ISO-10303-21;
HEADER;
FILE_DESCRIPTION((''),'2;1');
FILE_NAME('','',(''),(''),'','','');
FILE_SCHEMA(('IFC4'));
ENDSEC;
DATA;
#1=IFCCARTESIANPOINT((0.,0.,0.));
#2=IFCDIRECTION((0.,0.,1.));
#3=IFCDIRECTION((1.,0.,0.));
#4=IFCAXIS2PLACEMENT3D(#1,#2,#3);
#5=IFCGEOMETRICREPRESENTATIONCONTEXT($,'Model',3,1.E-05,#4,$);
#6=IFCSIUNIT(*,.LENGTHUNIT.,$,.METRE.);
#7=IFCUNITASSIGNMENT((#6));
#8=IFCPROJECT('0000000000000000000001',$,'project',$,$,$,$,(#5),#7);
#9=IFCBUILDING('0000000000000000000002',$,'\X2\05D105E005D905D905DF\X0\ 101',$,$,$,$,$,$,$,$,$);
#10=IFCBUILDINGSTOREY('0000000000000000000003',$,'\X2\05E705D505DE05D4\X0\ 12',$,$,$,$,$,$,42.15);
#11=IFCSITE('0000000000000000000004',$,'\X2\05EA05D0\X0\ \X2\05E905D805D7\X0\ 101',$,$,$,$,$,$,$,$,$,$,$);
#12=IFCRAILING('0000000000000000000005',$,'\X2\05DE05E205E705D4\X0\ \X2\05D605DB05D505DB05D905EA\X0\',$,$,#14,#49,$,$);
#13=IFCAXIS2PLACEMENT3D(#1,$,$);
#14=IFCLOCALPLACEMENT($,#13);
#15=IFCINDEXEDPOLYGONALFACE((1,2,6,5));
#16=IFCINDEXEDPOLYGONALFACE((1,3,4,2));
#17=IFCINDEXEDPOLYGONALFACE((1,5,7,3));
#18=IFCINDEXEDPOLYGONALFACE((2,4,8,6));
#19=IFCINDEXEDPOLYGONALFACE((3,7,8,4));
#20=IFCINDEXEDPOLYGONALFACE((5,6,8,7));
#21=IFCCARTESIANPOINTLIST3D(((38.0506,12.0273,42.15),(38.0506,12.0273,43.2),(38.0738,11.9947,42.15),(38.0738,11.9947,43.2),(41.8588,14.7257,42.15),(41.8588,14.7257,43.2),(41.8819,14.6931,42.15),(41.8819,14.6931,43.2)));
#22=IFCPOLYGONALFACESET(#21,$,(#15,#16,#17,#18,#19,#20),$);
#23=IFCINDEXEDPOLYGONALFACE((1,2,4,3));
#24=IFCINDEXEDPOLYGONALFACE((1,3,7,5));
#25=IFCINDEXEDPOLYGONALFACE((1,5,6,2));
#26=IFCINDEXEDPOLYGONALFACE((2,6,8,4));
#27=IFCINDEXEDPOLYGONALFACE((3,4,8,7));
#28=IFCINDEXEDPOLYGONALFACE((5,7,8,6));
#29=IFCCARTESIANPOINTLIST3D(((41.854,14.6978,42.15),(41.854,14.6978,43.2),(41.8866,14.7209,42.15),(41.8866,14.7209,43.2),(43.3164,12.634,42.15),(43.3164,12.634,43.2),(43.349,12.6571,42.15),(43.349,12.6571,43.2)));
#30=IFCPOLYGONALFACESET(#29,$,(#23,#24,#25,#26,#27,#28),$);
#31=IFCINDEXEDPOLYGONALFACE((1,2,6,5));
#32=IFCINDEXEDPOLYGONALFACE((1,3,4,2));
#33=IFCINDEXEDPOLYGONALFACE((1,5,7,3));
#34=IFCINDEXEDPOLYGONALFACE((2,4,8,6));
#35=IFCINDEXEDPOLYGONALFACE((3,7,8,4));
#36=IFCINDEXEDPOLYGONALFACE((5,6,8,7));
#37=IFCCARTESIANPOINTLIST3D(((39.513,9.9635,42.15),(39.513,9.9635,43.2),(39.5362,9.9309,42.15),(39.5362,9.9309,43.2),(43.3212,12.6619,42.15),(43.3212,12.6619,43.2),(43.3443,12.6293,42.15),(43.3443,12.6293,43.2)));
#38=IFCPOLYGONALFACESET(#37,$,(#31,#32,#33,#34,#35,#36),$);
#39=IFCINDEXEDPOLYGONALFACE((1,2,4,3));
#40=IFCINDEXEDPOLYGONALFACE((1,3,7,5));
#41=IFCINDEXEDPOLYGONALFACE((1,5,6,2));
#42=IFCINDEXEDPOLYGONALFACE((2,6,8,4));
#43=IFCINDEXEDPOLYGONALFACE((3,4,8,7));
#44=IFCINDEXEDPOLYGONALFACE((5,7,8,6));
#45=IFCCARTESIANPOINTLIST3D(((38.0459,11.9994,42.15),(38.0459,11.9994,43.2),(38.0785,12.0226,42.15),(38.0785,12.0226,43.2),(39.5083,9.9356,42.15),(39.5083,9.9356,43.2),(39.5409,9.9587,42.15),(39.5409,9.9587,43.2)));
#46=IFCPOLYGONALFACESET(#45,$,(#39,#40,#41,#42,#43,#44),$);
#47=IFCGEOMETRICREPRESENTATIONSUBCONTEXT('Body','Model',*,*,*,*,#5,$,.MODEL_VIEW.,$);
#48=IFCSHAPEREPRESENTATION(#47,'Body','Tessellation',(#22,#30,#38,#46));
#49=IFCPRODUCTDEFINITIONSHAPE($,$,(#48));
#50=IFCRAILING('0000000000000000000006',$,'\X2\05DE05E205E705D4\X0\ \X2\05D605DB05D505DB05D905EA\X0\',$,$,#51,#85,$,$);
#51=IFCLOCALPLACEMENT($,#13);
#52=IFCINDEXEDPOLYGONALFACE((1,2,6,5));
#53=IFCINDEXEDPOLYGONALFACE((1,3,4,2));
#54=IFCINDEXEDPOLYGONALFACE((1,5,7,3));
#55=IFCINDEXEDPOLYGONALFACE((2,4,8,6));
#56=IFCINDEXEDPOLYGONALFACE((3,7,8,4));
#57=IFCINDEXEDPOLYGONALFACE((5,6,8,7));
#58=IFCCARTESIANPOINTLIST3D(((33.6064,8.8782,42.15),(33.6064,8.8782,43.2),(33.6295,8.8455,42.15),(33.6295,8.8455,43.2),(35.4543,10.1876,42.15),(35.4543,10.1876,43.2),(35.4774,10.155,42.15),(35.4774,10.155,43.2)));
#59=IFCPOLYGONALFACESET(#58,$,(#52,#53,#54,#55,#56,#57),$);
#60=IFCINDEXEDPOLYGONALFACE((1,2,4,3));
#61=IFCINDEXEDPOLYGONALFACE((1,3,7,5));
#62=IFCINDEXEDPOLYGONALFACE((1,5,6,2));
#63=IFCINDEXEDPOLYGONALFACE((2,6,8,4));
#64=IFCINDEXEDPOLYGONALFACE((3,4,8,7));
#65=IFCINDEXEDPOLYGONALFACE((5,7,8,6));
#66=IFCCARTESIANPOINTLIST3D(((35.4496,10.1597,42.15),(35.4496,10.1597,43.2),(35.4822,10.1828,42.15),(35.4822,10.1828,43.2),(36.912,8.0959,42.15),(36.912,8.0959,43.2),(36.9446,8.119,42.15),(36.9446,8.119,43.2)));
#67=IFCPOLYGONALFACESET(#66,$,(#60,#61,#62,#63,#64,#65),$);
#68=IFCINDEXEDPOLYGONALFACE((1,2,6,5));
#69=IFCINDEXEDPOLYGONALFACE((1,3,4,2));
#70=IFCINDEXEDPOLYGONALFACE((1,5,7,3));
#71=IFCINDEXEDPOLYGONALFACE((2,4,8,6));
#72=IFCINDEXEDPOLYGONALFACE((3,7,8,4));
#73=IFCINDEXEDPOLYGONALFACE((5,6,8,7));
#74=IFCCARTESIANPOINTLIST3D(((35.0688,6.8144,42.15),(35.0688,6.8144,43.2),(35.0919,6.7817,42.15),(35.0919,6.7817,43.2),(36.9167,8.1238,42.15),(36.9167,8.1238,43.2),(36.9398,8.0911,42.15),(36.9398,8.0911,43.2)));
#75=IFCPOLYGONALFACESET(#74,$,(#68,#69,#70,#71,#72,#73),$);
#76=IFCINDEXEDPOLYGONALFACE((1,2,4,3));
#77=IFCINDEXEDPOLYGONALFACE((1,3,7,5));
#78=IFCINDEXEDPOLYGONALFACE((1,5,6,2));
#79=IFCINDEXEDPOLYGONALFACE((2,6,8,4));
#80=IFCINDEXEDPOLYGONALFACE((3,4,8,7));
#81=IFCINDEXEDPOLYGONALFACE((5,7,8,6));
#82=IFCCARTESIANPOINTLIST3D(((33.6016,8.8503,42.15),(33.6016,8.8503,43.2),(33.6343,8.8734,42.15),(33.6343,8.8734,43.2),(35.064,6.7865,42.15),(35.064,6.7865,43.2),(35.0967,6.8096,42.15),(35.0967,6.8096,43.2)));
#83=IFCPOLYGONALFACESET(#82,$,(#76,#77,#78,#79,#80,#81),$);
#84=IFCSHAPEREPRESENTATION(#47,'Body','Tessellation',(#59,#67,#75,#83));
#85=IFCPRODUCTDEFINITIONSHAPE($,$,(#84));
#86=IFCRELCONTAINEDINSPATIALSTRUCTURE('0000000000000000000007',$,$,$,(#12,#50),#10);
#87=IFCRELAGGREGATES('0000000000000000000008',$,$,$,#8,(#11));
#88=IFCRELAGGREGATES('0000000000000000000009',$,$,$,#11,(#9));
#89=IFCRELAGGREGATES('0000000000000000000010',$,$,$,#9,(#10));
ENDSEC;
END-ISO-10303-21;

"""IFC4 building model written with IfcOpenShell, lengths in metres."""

from ifc_helpers import new_model, si_unit, frame, origin_with_axes, context, subcontext, project, spatial, polyline, outline, extrude, element, save


model = new_model("IFC4")

# Units and contexts
model_context = context("Model", 3, precision=1e-05, world=origin_with_axes())
body_context = subcontext(model_context, "Body", "Model", "MODEL_VIEW")
ifc_project = project(units=[si_unit("LENGTHUNIT", "METRE")], contexts=[model_context])

# Site, building, storey
site = spatial("IfcSite", under=ifc_project, Name="תא שטח 101")
building = spatial("IfcBuilding", under=site, Name="בניין 101")
storey = spatial("IfcBuildingStorey", under=building, Name="קומה 12", Elevation=42.15)

# Railings
element("IfcRailing", 1, inside=storey, Name="מעקה זכוכית", context=body_context, shape_type="SweptSolid", body=[
    extrude(outline(polyline([(38.0738, 11.9947), (41.8819, 14.6931), (41.8588, 14.7257), (38.0506, 12.0273), (38.0738, 11.9947)])), frame((0.0, 0.0, 42.15)), (0.0, 0.0, 1.0), 1.05),
    extrude(outline(polyline([(41.854, 14.6978), (43.3164, 12.634), (43.349, 12.6571), (41.8866, 14.7209), (41.854, 14.6978)])), frame((0.0, 0.0, 42.15)), (0.0, 0.0, 1.0), 1.05),
    extrude(outline(polyline([(43.3212, 12.6619), (39.513, 9.9635), (39.5362, 9.9309), (43.3443, 12.6293), (43.3212, 12.6619)])), frame((0.0, 0.0, 42.15)), (0.0, 0.0, 1.0), 1.05),
    extrude(outline(polyline([(39.5409, 9.9587), (38.0785, 12.0226), (38.0459, 11.9994), (39.5083, 9.9356), (39.5409, 9.9587)])), frame((0.0, 0.0, 42.15)), (0.0, 0.0, 1.0), 1.05),
])
element("IfcRailing", 2, inside=storey, Name="מעקה זכוכית", context=body_context, shape_type="SweptSolid", body=[
    extrude(outline(polyline([(33.6295, 8.8455), (35.4774, 10.155), (35.4543, 10.1876), (33.6064, 8.8782), (33.6295, 8.8455)])), frame((0.0, 0.0, 42.15)), (0.0, 0.0, 1.0), 1.05),
    extrude(outline(polyline([(35.4496, 10.1597), (36.912, 8.0959), (36.9446, 8.119), (35.4822, 10.1828), (35.4496, 10.1597)])), frame((0.0, 0.0, 42.15)), (0.0, 0.0, 1.0), 1.05),
    extrude(outline(polyline([(36.9167, 8.1238), (35.0688, 6.8144), (35.0919, 6.7817), (36.9398, 8.0911), (36.9167, 8.1238)])), frame((0.0, 0.0, 42.15)), (0.0, 0.0, 1.0), 1.05),
    extrude(outline(polyline([(35.0967, 6.8096), (33.6343, 8.8734), (33.6016, 8.8503), (35.064, 6.7865), (35.0967, 6.8096)])), frame((0.0, 0.0, 42.15)), (0.0, 0.0, 1.0), 1.05),
])

save(model, "model.ifc")
